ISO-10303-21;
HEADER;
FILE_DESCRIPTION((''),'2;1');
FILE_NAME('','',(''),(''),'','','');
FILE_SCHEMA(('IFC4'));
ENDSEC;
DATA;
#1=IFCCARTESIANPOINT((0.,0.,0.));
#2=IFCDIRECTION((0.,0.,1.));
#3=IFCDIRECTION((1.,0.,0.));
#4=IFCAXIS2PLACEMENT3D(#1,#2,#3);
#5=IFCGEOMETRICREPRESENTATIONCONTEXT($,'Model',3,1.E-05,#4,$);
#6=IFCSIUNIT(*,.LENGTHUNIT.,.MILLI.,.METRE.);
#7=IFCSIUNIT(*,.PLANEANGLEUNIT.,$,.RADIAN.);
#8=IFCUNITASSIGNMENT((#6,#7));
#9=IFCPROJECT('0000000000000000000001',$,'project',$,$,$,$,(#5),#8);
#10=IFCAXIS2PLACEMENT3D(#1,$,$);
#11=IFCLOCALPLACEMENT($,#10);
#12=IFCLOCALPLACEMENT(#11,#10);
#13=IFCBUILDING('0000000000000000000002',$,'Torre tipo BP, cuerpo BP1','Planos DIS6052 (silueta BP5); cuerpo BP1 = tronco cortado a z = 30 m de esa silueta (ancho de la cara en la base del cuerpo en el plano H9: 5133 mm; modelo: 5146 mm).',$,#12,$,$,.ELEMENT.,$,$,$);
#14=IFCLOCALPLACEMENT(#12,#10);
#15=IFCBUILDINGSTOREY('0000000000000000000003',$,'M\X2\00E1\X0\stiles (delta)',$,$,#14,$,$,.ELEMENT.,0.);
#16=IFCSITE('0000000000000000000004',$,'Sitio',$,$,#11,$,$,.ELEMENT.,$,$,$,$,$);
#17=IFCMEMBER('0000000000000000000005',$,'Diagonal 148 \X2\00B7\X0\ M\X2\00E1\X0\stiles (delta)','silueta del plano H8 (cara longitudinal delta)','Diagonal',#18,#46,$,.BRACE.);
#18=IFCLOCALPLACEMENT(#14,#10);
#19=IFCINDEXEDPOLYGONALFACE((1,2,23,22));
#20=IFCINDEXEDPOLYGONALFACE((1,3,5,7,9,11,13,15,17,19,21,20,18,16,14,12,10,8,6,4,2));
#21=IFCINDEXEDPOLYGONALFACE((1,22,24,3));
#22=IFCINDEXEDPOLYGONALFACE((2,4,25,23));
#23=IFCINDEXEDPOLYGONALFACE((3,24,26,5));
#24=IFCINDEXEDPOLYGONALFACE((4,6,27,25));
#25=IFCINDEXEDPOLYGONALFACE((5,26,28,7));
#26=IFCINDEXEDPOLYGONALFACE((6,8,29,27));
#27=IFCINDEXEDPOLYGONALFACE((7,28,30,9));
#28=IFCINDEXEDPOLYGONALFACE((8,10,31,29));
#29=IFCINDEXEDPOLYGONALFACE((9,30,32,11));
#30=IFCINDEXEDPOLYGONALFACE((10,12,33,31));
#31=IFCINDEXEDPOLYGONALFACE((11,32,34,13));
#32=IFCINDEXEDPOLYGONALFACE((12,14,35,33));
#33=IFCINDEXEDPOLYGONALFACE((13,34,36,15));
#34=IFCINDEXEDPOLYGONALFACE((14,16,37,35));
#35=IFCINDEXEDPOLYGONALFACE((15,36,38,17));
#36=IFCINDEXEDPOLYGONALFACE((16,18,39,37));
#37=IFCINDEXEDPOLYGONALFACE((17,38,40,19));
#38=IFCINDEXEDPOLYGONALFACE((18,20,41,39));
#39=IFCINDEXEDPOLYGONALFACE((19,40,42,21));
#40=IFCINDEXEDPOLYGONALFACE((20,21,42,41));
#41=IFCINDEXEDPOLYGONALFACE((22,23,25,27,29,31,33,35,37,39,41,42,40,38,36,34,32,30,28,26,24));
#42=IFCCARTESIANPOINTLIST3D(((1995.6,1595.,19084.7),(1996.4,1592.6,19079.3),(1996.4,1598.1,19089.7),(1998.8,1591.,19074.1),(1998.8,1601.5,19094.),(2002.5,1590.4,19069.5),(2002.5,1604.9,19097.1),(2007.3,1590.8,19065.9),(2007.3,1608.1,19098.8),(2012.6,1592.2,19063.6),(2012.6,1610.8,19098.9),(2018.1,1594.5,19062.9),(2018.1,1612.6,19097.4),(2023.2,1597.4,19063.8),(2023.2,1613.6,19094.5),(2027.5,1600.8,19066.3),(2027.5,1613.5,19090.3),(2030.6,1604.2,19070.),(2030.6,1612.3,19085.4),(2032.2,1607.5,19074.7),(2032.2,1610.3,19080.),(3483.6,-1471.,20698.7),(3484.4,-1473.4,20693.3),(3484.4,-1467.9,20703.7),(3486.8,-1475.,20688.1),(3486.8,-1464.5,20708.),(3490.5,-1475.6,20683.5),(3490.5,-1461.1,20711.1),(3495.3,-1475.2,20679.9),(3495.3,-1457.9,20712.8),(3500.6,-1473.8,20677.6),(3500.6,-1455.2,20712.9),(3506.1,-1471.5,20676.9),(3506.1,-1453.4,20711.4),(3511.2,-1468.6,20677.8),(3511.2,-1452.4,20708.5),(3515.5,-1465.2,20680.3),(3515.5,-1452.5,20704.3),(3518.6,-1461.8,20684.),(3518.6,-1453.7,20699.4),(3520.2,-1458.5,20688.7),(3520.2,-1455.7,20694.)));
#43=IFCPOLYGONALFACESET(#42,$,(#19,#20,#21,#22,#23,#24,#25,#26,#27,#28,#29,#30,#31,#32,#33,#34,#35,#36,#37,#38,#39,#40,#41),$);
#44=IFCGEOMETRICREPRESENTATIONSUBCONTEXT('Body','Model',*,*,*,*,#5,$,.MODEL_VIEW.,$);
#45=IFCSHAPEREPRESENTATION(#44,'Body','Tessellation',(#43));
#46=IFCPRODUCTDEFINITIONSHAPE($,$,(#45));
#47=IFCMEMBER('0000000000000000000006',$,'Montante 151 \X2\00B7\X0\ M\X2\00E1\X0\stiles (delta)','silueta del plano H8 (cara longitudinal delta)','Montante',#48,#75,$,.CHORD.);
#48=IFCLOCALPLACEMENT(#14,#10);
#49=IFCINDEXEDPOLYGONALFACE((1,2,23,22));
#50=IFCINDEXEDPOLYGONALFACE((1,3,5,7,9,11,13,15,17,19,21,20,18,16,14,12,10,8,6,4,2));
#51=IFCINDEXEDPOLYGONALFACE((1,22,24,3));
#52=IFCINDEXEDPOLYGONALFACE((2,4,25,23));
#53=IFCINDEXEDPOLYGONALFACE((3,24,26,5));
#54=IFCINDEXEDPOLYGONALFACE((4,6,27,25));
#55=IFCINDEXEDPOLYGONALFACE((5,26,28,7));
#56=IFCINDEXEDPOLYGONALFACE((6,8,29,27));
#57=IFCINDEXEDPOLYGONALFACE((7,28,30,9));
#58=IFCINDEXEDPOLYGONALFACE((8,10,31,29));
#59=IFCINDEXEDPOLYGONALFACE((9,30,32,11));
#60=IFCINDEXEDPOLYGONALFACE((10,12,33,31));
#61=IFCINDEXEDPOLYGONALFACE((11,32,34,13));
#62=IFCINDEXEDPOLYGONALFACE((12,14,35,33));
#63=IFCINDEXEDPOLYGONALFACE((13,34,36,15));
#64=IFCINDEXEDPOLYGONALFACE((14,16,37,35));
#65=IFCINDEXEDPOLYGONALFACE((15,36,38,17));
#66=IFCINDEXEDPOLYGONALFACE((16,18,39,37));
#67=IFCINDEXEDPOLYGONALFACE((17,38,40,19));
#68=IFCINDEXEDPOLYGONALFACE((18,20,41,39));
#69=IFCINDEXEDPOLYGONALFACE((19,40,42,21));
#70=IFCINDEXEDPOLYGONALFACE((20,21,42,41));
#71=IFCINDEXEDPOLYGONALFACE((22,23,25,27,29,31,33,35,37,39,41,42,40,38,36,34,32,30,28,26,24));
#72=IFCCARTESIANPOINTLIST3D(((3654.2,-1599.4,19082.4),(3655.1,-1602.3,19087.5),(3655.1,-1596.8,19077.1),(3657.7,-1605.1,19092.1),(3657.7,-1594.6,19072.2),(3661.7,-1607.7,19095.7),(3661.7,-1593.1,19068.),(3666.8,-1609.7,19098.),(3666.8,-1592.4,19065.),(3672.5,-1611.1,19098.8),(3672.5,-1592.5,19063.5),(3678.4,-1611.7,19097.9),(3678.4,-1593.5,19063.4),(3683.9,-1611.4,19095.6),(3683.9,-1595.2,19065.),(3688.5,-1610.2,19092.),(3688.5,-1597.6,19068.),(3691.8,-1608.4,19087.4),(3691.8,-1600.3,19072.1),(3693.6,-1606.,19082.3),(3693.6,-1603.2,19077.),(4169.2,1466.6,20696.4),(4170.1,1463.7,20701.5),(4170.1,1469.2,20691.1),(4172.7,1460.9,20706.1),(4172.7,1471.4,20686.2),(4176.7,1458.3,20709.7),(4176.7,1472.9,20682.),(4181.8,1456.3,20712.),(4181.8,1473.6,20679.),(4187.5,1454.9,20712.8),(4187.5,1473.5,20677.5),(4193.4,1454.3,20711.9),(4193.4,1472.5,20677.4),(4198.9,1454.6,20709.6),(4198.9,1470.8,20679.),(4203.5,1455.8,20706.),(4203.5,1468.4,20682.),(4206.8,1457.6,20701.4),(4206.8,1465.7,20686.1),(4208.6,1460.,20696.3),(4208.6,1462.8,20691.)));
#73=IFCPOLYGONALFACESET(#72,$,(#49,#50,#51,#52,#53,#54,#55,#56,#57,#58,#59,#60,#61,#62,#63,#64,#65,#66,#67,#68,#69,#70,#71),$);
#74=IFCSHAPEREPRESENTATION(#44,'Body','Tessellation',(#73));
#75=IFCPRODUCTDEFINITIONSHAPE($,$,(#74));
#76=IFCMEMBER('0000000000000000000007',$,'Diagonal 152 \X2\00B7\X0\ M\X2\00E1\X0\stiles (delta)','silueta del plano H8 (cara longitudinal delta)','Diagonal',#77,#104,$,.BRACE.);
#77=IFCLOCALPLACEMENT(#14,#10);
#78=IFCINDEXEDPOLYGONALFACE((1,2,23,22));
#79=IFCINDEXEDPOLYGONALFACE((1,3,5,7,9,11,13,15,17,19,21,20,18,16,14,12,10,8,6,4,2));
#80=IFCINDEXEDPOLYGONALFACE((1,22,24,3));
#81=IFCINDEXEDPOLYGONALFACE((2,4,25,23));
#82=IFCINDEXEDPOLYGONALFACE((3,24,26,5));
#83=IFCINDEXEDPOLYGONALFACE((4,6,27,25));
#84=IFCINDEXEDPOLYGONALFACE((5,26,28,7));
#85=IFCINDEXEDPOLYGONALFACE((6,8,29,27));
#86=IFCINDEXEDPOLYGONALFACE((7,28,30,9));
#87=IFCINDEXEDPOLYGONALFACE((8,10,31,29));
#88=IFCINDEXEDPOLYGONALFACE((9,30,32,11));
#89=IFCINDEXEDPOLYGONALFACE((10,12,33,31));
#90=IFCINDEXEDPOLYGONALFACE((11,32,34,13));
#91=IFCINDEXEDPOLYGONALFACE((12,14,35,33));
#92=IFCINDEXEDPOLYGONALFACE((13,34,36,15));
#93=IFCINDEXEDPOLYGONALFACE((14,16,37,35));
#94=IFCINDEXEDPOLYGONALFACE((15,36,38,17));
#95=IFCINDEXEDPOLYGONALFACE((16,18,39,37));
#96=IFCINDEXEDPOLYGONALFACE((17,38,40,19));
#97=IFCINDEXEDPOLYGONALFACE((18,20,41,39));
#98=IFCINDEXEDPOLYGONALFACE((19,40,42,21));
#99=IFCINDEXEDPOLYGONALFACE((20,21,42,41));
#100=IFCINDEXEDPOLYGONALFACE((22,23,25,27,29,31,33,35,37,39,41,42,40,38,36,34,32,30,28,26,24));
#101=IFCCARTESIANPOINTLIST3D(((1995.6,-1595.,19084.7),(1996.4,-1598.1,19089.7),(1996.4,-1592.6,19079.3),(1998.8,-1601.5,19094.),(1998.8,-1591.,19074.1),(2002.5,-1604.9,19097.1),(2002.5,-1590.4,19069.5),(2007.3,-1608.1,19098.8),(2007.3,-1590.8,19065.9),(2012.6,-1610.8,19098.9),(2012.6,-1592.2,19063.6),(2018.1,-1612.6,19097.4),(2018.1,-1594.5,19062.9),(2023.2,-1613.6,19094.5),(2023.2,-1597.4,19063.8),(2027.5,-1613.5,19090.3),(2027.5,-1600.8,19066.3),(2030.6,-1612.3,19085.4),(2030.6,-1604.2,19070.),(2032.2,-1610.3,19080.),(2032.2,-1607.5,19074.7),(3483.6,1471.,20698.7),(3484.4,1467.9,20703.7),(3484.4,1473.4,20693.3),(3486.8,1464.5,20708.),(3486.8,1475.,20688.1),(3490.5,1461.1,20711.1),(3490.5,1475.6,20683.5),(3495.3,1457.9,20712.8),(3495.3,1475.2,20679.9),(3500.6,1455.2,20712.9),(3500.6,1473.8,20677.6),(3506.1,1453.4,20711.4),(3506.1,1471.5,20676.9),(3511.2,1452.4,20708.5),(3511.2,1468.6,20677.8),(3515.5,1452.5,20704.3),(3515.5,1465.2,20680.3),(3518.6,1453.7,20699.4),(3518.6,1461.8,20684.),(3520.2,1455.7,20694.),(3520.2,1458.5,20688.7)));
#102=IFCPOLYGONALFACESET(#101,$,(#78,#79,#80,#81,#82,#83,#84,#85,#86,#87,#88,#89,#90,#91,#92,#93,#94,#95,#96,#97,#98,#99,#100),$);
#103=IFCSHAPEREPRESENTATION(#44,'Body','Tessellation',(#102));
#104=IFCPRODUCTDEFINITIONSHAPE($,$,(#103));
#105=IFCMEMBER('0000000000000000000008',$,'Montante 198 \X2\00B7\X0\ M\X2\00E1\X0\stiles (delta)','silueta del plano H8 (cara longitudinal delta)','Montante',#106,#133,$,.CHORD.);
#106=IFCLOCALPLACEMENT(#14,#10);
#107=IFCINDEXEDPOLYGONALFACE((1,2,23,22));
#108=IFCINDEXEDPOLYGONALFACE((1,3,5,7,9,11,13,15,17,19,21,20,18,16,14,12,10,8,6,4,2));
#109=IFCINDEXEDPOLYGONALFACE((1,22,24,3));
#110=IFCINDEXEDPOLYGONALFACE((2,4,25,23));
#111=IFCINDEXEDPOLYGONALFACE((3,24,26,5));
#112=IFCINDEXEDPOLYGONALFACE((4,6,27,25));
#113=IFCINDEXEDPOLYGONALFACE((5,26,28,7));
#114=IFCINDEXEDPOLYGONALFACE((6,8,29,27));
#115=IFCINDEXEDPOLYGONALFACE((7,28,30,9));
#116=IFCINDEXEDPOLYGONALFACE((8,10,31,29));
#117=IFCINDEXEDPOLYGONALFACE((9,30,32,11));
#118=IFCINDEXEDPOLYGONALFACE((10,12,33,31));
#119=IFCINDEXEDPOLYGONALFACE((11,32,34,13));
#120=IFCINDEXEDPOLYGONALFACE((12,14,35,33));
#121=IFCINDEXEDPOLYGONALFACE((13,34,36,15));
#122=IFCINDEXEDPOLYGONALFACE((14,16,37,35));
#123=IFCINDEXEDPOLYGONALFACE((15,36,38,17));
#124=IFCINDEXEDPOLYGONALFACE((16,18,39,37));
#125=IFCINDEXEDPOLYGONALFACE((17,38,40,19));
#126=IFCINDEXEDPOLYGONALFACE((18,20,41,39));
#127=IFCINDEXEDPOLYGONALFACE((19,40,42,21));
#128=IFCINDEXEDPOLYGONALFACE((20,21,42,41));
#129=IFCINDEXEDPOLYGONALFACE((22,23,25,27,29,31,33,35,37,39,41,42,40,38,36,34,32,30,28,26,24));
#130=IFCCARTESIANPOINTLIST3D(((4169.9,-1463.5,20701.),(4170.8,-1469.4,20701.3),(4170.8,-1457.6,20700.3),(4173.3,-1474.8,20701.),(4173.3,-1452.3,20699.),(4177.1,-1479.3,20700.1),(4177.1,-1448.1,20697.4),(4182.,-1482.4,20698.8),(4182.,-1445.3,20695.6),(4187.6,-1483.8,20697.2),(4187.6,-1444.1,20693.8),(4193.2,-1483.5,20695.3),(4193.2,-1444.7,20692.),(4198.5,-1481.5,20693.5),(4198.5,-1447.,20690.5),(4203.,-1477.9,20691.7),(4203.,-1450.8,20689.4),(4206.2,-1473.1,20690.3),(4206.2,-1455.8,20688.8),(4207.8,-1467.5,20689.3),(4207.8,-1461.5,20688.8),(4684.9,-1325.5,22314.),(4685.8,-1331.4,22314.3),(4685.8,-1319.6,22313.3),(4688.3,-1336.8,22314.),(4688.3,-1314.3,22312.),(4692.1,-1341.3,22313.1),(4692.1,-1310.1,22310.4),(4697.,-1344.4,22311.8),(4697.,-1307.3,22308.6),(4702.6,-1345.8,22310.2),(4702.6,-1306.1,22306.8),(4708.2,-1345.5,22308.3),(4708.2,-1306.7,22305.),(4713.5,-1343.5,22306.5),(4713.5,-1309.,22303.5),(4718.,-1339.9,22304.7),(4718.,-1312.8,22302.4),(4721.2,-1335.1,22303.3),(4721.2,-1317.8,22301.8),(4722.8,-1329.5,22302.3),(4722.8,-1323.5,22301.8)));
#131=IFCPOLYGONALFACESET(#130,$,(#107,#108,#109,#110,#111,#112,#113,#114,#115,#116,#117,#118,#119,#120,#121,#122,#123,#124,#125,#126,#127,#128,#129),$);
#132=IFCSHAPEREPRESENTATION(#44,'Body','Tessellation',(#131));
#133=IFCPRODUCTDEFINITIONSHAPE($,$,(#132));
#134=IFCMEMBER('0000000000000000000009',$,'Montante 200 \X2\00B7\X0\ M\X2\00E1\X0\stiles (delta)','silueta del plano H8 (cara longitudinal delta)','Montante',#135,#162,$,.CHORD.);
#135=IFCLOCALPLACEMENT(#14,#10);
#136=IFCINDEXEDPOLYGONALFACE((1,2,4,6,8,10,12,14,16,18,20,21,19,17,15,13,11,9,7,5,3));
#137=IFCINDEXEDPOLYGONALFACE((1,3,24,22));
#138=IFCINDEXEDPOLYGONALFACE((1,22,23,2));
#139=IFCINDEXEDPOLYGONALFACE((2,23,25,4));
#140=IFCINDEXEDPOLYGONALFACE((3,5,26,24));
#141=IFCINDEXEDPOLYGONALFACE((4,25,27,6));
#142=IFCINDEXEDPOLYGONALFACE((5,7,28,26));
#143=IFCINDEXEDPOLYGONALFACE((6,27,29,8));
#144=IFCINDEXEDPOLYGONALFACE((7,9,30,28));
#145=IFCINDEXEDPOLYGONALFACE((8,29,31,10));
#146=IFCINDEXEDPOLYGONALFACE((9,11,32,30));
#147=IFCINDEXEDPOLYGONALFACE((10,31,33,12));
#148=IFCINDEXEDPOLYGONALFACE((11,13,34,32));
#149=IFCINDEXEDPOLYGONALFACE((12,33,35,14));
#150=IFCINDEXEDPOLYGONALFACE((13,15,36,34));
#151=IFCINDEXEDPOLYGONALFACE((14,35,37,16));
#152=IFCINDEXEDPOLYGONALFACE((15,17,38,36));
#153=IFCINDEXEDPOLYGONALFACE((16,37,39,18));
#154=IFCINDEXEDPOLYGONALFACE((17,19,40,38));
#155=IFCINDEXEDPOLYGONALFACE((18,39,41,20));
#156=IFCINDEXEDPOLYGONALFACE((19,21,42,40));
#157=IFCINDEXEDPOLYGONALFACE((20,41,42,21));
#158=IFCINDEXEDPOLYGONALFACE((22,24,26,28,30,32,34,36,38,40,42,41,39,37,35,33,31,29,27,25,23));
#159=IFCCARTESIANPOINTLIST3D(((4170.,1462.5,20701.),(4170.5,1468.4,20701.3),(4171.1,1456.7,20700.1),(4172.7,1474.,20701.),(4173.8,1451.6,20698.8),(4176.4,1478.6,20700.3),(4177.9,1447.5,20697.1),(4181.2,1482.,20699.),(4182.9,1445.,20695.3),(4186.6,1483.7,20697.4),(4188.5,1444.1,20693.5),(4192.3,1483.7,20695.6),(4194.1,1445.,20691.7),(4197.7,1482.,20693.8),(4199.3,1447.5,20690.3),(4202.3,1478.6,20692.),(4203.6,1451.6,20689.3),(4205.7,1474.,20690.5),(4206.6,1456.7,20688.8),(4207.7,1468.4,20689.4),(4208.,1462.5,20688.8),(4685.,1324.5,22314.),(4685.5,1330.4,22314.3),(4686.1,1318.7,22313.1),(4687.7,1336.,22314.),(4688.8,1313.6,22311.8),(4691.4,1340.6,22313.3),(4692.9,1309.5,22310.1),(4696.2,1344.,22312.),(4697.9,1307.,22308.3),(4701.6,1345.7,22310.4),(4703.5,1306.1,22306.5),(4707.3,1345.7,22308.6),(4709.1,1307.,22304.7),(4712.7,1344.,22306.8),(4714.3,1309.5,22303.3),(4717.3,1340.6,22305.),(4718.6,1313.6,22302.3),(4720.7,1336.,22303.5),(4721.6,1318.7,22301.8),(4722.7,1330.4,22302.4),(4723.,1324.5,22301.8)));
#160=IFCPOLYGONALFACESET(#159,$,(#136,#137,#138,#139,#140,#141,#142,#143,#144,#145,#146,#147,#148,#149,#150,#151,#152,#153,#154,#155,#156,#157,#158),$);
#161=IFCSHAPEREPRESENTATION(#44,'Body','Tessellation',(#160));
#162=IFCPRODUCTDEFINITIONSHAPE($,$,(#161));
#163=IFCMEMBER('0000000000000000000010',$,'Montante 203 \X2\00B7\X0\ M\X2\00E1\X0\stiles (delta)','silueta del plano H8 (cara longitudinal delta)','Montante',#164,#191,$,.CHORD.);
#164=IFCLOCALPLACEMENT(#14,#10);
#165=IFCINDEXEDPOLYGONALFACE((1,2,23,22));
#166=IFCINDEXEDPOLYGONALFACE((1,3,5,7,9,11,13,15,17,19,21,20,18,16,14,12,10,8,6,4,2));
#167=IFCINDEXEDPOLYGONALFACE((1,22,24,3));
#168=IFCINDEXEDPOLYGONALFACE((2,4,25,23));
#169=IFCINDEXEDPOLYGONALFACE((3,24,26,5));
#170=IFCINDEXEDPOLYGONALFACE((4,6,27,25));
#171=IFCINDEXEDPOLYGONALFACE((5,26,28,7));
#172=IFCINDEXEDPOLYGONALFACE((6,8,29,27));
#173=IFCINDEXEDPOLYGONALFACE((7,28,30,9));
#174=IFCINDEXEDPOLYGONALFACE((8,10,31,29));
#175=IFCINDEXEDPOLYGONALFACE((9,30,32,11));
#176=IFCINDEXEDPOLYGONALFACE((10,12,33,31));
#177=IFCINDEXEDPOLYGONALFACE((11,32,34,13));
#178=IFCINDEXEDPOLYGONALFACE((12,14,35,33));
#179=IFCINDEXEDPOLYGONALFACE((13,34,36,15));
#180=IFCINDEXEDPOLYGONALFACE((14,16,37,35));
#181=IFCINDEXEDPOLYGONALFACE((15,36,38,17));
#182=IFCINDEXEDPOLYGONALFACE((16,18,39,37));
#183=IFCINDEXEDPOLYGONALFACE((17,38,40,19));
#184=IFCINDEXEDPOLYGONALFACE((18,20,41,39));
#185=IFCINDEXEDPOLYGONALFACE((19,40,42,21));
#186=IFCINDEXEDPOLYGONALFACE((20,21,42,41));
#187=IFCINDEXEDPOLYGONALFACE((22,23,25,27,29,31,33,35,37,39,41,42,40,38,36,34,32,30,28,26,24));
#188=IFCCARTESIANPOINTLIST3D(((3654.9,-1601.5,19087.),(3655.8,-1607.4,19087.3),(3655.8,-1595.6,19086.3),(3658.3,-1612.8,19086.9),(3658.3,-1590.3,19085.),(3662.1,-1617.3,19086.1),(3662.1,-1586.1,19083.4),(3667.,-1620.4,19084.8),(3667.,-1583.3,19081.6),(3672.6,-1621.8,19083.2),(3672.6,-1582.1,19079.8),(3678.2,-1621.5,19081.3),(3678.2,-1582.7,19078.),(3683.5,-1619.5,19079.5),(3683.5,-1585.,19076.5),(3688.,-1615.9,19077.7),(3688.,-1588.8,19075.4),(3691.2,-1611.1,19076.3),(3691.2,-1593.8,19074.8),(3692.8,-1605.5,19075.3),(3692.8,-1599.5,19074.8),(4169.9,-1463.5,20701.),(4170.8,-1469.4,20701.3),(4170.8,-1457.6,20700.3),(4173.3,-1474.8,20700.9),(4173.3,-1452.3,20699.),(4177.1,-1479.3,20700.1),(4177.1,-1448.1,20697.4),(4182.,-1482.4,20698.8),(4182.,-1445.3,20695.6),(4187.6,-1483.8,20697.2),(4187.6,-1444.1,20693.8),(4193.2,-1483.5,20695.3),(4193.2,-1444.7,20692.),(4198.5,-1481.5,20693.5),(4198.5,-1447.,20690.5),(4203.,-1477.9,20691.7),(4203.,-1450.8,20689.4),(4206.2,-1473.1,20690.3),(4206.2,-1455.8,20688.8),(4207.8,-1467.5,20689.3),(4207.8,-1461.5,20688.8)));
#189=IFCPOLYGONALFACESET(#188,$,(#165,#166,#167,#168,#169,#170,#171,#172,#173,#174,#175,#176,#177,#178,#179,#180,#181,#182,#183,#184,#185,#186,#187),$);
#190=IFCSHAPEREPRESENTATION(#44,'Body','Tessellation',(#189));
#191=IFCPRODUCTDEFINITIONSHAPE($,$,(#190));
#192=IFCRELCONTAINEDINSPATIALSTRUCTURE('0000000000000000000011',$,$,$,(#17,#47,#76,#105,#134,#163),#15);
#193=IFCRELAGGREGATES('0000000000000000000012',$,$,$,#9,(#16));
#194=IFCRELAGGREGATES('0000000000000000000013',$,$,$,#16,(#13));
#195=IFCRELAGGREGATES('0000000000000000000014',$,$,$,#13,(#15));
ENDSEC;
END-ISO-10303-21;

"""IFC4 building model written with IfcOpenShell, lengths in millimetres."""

from ifc_helpers import new_model, si_unit, frame, origin, origin_with_axes, place, context, subcontext, project, spatial, circle, extrude, element, save


model = new_model("IFC4")

# Units and contexts
model_context = context("Model", 3, precision=1e-05, world=origin_with_axes())
body_context = subcontext(model_context, "Body", "Model", "MODEL_VIEW")
ifc_project = project(units=[si_unit("LENGTHUNIT", "METRE", prefix="MILLI"), si_unit("PLANEANGLEUNIT", "RADIAN")], contexts=[model_context])

# Site, building, storey
site_placement = place(None, origin())
site = spatial("IfcSite", under=ifc_project, at=site_placement, Name="Sitio", CompositionType="ELEMENT")
building_placement = place(site_placement, origin())
building = spatial("IfcBuilding", under=site, at=building_placement, Name="Torre tipo BP, cuerpo BP1", Description="Planos DIS6052 (silueta BP5); cuerpo BP1 = tronco cortado a z = 30 m de esa silueta (ancho de la cara en la base del cuerpo en el plano H9: 5133 mm; modelo: 5146 mm).", CompositionType="ELEMENT")
storey_placement = place(building_placement, origin())
storey = spatial("IfcBuildingStorey", under=building, at=storey_placement, Name="Mástiles (delta)", CompositionType="ELEMENT", Elevation=0.0)

# Members
member_1_placement = place(storey_placement, frame((3502.0, -1464.0, 20695.0), z_axis=(-0.394603, 0.813074, -0.428017), x_axis=(-0.918852, -0.349177, 0.183813)))
element("IfcMember", 1, at=member_1_placement, inside=storey, Name="Diagonal 148 · Mástiles (delta)", Description="silueta del plano H8 (cara longitudinal delta)", ObjectType="Diagonal", PredefinedType="BRACE", context=body_context, shape_type="SweptSolid", body=[
    extrude(circle(Radius=20.0), None, (0.0, 0.0, 1.0), 3770.9),
])
member_2_placement = place(storey_placement, frame((4189.0, 1464.0, 20695.0), z_axis=(-0.147019, -0.875265, -0.460756), x_axis=(-0.989134, 0.130095, 0.068484)))
element("IfcMember", 2, at=member_2_placement, inside=storey, Name="Montante 151 · Mástiles (delta)", Description="silueta del plano H8 (cara longitudinal delta)", ObjectType="Montante", PredefinedType="CHORD", context=body_context, shape_type="SweptSolid", body=[
    extrude(circle(Radius=20.0), None, (0.0, 0.0, 1.0), 3502.9),
])
member_3_placement = place(storey_placement, frame((3502.0, 1464.0, 20695.0), z_axis=(-0.394603, -0.813074, -0.428017), x_axis=(-0.918852, 0.349177, 0.183813)))
element("IfcMember", 3, at=member_3_placement, inside=storey, Name="Diagonal 152 · Mástiles (delta)", Description="silueta del plano H8 (cara longitudinal delta)", ObjectType="Diagonal", PredefinedType="BRACE", context=body_context, shape_type="SweptSolid", body=[
    extrude(circle(Radius=20.0), None, (0.0, 0.0, 1.0), 3770.9),
])
for number, where, z_axis, x_axis, name in (
    (4, (4704.0, -1326.0, 22308.0), (-0.303149, -0.081232, -0.949475), (-0.952943, 0.025841, 0.302046), "Montante 198 · Mástiles (delta)"),
    (5, (4704.0, 1326.0, 22308.0), (-0.303149, 0.081232, -0.949475), (-0.024707, -0.996695, -0.077384), "Montante 200 · Mástiles (delta)"),
):
    element("IfcMember", number, at=place(storey_placement, frame(where, z_axis=z_axis, x_axis=x_axis)), inside=storey, Name=name, Description="silueta del plano H8 (cara longitudinal delta)", ObjectType="Montante", PredefinedType="CHORD", context=body_context, shape_type="SweptSolid", body=[
        extrude(circle(Radius=20.0), None, (0.0, 0.0, 1.0), 1698.8),
    ])
member_4_placement = place(storey_placement, frame((4189.0, -1464.0, 20695.0), z_axis=(-0.30298, -0.081187, -0.949533), x_axis=(-0.952997, 0.025811, 0.301878)))
element("IfcMember", 6, at=member_4_placement, inside=storey, Name="Montante 203 · Mástiles (delta)", Description="silueta del plano H8 (cara longitudinal delta)", ObjectType="Montante", PredefinedType="CHORD", context=body_context, shape_type="SweptSolid", body=[
    extrude(circle(Radius=20.0), None, (0.0, 0.0, 1.0), 1699.8),
])

save(model, "model.ifc")
